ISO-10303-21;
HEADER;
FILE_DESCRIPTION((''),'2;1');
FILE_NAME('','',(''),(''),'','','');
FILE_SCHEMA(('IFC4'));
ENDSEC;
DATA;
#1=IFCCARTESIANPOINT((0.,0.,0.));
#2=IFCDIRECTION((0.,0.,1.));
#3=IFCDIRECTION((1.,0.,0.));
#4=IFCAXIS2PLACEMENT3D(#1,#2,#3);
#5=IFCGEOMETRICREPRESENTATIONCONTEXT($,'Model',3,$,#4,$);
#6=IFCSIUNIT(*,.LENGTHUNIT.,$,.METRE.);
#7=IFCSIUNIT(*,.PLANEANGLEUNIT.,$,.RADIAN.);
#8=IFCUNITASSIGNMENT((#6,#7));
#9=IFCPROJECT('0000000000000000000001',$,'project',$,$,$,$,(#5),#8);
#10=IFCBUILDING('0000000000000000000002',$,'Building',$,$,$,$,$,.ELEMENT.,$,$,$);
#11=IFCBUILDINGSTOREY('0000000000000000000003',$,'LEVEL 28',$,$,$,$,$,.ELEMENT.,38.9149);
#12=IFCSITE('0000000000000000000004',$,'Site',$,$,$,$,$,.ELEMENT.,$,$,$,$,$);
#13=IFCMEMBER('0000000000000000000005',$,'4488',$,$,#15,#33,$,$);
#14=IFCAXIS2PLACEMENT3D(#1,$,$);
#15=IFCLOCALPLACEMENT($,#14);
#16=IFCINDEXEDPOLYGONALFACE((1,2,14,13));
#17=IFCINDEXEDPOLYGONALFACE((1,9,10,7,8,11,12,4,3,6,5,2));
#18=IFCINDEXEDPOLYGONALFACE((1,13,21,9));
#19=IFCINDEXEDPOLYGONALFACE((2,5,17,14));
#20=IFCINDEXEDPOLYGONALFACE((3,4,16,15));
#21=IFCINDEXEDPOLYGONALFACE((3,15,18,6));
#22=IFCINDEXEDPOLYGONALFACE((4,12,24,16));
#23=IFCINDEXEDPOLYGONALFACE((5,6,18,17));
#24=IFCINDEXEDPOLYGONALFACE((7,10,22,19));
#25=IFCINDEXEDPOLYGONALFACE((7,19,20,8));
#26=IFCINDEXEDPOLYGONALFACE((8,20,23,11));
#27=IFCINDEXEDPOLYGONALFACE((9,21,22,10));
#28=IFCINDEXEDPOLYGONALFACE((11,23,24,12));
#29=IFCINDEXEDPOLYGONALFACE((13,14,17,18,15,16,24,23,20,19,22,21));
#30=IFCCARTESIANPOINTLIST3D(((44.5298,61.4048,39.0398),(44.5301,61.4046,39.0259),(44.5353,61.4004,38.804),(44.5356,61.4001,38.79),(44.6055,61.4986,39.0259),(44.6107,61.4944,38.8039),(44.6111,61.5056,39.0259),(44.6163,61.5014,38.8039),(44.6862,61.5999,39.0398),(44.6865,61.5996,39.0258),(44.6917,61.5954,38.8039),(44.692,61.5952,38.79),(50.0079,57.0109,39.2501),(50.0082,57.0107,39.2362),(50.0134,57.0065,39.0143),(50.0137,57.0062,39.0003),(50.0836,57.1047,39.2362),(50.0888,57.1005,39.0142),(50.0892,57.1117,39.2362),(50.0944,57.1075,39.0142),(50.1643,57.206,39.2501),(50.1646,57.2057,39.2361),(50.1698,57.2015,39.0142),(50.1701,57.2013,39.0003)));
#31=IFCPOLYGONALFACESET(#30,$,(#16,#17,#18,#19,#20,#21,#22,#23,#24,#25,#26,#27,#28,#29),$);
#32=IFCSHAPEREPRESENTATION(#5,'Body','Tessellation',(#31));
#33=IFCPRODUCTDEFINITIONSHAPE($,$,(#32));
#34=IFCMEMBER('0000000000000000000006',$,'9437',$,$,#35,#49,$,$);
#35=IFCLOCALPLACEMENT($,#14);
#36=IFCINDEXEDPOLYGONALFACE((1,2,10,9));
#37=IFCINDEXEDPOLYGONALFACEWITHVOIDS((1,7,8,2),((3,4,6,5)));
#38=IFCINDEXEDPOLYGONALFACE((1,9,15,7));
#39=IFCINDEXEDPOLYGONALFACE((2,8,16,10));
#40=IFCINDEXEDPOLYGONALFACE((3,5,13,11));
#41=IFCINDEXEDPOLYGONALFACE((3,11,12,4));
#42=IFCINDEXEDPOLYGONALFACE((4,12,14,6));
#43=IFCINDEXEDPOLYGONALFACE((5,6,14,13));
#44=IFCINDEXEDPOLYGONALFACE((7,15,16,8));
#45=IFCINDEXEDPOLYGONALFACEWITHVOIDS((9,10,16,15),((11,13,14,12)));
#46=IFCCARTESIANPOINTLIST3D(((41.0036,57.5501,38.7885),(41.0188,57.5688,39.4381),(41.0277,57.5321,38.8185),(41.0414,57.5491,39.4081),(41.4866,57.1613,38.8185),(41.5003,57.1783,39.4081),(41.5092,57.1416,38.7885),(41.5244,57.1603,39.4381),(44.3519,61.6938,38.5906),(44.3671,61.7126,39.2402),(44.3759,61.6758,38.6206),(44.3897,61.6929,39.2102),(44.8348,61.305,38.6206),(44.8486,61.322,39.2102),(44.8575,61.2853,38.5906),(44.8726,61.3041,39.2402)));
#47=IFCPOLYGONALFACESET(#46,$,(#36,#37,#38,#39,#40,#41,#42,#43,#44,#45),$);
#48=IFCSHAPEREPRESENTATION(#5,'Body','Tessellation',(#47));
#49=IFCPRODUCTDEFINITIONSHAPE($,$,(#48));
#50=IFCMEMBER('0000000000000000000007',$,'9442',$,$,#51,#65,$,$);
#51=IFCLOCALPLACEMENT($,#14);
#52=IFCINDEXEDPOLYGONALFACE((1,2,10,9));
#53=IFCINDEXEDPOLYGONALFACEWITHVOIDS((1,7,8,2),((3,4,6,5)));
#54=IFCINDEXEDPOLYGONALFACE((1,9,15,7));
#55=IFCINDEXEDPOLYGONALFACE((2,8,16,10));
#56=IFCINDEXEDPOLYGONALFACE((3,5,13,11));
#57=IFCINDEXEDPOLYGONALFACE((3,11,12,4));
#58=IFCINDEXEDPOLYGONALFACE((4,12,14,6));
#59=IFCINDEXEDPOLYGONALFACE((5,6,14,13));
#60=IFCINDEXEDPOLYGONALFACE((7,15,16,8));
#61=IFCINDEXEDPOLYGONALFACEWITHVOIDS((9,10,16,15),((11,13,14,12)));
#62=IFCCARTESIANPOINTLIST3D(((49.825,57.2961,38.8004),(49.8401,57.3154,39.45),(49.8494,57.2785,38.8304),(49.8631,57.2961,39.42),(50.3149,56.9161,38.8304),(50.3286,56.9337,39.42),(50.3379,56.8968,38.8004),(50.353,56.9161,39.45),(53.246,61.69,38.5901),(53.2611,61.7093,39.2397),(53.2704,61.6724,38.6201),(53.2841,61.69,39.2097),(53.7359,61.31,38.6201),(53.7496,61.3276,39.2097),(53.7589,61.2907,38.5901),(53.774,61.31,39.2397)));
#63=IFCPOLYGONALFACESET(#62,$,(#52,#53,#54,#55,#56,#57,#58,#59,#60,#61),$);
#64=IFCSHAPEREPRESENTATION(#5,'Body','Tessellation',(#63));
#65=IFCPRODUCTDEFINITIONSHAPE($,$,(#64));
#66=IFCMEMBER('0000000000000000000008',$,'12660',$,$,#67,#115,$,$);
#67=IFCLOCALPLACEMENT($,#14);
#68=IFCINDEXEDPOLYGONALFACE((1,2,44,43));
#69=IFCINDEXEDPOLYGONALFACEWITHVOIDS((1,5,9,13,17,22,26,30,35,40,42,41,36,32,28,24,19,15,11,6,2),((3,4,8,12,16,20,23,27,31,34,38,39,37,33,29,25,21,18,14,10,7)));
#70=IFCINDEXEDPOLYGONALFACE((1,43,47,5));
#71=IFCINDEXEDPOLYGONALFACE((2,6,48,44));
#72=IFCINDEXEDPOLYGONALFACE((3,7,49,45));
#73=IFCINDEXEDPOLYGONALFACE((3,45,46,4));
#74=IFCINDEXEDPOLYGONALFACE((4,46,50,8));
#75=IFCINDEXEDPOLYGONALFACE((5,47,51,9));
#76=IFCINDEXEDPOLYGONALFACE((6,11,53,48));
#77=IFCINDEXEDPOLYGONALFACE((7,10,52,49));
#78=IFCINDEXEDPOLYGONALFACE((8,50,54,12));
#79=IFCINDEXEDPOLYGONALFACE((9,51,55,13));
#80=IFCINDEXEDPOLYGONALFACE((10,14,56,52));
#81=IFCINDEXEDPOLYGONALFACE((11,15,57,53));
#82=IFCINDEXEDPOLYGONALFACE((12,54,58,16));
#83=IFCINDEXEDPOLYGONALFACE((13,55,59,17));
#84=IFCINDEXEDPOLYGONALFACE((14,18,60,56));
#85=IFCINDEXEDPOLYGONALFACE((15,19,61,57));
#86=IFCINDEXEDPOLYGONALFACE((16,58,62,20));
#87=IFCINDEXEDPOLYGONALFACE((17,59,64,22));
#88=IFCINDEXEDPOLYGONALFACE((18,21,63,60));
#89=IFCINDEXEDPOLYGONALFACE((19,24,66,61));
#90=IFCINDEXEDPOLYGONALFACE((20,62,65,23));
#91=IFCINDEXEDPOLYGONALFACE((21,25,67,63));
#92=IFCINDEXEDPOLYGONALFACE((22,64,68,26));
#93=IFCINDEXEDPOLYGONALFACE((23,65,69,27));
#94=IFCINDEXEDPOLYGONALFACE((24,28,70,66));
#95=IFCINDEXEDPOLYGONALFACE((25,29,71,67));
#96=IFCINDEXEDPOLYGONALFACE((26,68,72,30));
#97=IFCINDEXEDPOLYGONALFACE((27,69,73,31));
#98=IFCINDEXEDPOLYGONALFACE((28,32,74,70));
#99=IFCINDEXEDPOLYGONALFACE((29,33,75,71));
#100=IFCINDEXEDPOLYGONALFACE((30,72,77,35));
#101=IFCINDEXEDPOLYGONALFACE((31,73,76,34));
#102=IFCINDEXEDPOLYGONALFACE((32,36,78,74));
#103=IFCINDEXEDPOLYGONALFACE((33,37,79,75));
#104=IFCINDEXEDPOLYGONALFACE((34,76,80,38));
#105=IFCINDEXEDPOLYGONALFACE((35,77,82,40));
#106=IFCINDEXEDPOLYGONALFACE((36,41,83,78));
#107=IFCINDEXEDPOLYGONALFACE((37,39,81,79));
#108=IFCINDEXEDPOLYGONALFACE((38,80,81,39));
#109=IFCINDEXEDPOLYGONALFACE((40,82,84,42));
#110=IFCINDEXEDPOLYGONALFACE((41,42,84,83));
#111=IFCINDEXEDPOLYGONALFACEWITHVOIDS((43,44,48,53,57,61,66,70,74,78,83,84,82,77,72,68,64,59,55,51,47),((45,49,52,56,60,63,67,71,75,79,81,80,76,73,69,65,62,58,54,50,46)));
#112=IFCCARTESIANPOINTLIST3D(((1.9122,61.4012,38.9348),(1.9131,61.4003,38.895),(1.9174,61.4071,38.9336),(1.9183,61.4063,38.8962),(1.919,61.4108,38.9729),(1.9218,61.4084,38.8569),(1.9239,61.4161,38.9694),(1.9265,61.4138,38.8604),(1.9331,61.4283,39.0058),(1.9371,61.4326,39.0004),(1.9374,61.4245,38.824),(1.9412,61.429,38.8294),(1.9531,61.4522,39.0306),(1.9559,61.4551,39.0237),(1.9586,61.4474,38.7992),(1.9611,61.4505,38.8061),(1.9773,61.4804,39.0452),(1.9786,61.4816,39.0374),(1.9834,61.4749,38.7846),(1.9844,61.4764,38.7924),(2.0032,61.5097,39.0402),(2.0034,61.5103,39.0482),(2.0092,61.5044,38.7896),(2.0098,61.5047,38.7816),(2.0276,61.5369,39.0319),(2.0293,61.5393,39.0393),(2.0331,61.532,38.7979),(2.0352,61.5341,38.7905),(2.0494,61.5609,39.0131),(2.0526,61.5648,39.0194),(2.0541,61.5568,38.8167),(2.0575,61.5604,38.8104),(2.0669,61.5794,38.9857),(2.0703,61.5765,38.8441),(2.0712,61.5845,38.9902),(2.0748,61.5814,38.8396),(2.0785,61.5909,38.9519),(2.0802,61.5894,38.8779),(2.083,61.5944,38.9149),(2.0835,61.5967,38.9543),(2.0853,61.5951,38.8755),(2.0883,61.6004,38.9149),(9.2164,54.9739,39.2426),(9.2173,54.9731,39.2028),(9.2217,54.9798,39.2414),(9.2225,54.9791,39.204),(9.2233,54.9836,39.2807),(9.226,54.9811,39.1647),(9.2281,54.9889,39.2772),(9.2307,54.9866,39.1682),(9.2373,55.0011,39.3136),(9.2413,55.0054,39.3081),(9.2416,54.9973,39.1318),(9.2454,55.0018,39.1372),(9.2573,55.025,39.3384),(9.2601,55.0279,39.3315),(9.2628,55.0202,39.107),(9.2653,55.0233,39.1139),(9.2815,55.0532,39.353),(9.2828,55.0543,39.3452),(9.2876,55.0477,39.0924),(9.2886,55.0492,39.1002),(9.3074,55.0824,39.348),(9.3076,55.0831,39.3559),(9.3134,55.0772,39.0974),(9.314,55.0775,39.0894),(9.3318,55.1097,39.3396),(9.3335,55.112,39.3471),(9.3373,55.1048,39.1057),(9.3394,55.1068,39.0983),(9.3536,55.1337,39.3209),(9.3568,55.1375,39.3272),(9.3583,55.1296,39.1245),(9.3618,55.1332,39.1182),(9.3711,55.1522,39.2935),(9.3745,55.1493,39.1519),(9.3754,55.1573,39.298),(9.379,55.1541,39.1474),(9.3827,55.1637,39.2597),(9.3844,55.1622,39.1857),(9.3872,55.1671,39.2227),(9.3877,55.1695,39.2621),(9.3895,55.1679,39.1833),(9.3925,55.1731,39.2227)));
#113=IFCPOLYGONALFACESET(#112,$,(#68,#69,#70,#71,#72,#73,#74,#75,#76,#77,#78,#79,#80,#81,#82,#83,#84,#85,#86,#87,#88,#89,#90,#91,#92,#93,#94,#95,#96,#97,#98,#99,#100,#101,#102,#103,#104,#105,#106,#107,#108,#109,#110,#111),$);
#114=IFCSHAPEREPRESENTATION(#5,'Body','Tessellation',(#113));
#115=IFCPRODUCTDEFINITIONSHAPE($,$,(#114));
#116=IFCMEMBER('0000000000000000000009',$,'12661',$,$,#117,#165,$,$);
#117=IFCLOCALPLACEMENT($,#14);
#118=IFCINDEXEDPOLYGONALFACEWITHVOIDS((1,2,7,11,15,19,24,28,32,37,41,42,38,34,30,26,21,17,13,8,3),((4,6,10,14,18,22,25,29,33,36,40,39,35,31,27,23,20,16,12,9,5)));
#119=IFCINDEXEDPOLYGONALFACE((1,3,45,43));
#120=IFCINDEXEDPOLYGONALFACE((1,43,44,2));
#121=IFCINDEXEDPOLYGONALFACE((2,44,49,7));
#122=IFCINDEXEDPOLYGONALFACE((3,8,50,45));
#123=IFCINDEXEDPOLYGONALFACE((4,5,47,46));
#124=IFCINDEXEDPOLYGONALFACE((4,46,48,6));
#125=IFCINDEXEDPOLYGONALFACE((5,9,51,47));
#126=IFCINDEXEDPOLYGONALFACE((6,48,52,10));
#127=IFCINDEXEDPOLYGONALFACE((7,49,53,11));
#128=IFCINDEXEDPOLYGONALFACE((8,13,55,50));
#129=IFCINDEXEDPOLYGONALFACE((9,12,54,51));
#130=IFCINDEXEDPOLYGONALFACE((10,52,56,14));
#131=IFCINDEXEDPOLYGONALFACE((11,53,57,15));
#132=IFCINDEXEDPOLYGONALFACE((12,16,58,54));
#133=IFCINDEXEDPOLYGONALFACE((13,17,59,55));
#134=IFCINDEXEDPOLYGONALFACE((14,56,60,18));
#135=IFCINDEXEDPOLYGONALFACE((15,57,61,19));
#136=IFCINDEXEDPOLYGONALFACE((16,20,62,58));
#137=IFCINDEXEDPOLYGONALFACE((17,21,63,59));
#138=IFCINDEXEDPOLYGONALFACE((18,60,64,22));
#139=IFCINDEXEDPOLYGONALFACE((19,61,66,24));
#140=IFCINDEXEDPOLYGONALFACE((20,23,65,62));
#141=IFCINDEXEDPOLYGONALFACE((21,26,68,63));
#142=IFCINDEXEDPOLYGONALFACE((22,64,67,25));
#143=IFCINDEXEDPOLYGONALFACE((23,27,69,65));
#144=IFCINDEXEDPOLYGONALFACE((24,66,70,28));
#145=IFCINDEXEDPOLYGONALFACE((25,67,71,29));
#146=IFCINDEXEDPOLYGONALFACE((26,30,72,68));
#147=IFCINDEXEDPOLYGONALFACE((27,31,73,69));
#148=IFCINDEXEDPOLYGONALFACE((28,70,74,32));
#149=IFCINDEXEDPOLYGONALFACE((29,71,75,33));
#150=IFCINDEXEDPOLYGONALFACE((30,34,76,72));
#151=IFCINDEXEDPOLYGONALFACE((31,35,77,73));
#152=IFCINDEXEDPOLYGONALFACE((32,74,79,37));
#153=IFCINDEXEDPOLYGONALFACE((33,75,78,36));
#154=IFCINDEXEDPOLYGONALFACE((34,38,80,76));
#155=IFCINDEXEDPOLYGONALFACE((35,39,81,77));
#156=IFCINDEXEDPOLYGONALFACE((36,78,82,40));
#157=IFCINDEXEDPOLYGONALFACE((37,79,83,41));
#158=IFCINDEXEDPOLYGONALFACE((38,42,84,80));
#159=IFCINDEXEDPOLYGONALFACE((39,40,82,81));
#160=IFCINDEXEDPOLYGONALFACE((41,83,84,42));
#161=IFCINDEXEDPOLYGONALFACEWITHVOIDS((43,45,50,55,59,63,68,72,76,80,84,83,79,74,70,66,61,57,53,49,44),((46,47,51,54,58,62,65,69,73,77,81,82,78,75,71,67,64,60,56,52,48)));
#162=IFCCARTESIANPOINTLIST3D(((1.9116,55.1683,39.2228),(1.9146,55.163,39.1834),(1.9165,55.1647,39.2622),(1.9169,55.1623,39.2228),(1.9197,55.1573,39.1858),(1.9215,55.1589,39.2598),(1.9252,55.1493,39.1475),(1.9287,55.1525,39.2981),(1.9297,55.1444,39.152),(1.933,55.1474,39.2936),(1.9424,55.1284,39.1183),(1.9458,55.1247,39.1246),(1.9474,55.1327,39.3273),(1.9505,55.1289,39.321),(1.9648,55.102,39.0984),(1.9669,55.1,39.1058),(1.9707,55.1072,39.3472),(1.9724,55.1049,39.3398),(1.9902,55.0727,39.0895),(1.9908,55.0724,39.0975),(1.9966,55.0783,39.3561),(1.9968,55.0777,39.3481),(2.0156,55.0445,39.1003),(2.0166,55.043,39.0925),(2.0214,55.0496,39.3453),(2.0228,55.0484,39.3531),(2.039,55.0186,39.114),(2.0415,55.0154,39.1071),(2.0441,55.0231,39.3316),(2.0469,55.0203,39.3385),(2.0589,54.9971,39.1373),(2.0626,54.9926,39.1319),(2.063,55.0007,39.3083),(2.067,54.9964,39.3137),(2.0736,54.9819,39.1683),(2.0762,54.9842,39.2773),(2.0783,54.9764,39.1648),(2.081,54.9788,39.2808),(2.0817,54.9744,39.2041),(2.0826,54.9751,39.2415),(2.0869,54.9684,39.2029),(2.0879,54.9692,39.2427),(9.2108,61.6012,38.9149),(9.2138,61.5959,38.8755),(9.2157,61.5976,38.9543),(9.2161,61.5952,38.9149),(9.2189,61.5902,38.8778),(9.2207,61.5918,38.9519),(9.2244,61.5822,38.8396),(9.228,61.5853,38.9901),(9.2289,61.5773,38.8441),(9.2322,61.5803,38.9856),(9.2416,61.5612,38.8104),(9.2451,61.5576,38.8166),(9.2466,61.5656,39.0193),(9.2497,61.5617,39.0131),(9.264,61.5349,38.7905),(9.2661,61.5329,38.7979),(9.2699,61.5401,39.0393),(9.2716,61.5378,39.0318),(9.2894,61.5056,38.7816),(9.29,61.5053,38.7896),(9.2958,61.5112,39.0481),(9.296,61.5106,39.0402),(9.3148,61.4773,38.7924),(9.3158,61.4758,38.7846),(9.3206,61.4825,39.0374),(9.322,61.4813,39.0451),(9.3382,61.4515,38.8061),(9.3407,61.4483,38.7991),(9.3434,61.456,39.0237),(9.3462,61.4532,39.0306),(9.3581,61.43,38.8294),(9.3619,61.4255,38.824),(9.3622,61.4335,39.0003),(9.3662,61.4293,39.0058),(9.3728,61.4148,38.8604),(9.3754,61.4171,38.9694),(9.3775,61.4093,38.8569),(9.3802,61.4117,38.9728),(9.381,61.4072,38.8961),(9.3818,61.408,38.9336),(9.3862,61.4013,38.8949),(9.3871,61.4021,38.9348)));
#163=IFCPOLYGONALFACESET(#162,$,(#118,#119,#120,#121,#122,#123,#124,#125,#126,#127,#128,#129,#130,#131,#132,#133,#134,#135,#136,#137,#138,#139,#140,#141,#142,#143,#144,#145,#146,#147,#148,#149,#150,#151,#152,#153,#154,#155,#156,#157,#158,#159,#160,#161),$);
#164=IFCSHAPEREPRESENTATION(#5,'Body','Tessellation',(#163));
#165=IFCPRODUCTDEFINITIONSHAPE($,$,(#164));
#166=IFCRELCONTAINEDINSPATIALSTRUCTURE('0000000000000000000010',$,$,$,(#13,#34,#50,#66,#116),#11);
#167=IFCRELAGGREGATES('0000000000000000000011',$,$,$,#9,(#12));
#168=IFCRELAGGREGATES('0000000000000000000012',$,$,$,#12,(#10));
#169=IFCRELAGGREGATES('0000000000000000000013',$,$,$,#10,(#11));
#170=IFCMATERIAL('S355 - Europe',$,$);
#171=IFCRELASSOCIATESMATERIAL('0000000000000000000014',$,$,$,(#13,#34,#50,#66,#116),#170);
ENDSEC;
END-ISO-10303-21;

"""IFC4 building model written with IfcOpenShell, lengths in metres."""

from ifc_helpers import new_model, si_unit, frame, origin_with_axes, origin_2d_with_axis, place, context, project, spatial, hollow_rectangle, hollow_circle, i_section, extrude, material, material_profile, profile_set, profile_usage, element, save


model = new_model("IFC4")

# Units and contexts
model_context = context("Model", 3, world=origin_with_axes())
ifc_project = project(units=[si_unit("LENGTHUNIT", "METRE"), si_unit("PLANEANGLEUNIT", "RADIAN")], contexts=[model_context])

# Site, building, storey
site = spatial("IfcSite", under=ifc_project, Name="Site", CompositionType="ELEMENT")
building = spatial("IfcBuilding", under=site, Name="Building", CompositionType="ELEMENT")
storey = spatial("IfcBuildingStorey", under=building, Name="LEVEL 28", CompositionType="ELEMENT", Elevation=38.9149)

# Shared definitions
ifc_material = material(Name="S355 - Europe")

# Members
ifc_material_profile_1 = material_profile(ifc_material, i_section(OverallWidth=0.25, OverallDepth=0.25, WebThickness=0.009, FlangeThickness=0.014, at=origin_2d_with_axis()))
ifc_profile_set_1 = profile_set([ifc_material_profile_1])
ifc_profile_usage_1 = profile_usage(ifc_profile_set_1, cardinal=10)
member_1_placement = place(None, frame((50.089, 57.1061, 39.1252), z_axis=(-0.779725, 0.625406, -0.029933), x_axis=(-0.626214, -0.779651, 0.0)))
element("IfcMember", 1, at=member_1_placement, inside=storey, material=ifc_profile_usage_1, Name="4488", context=model_context, shape_type="SweptSolid", body=[
    extrude(i_section(OverallWidth=0.25, OverallDepth=0.25, WebThickness=0.009, FlangeThickness=0.014, at=origin_2d_with_axis()), origin_with_axes(), (0.0, 0.0, 1.0), 7.0257),
])
ifc_material_profile_2 = material_profile(ifc_material, hollow_rectangle(XDim=0.65, YDim=0.65, WallThickness=0.03, at=origin_2d_with_axis()))
ifc_profile_set_2 = profile_set([ifc_material_profile_2])
ifc_profile_usage_2 = profile_usage(ifc_profile_set_2, cardinal=10)
member_2_placement = place(None, frame((41.264, 57.3552, 39.1133), z_axis=(0.628063, 0.777276, -0.037125), x_axis=(-0.777826, 0.62848, 0.0)))
element("IfcMember", 2, at=member_2_placement, inside=storey, material=ifc_profile_usage_2, Name="9437", context=model_context, shape_type="SweptSolid", body=[
    extrude(hollow_rectangle(XDim=0.65, YDim=0.65, WallThickness=0.03, at=origin_2d_with_axis()), origin_with_axes(), (0.0, 0.0, 1.0), 5.3311),
])
ifc_material_profile_3 = material_profile(ifc_material, hollow_rectangle(XDim=0.65, YDim=0.65, WallThickness=0.03, at=origin_2d_with_axis()))
ifc_profile_set_3 = profile_set([ifc_material_profile_3])
ifc_profile_usage_3 = profile_usage(ifc_profile_set_3, cardinal=10)
member_3_placement = place(None, frame((53.51, 61.5, 38.9149), z_axis=(-0.613897, -0.788484, 0.037738), x_axis=(0.789796, -0.61337, 0.0)))
element("IfcMember", 3, at=member_3_placement, inside=storey, material=ifc_profile_usage_3, Name="9442", context=model_context, shape_type="SweptSolid", body=[
    extrude(hollow_rectangle(XDim=0.65, YDim=0.65, WallThickness=0.03, at=origin_2d_with_axis()), origin_with_axes(), (0.0, 0.0, 1.0), 5.5726),
])
ifc_material_profile_4 = material_profile(ifc_material, hollow_circle(Radius=0.1337, WallThickness=0.008, at=origin_2d_with_axis()))
ifc_profile_set_4 = profile_set([ifc_material_profile_4])
ifc_profile_usage_4 = profile_usage(ifc_profile_set_4, cardinal=10)
member_4_placement = place(None, frame((2.0, 61.5, 38.9149), z_axis=(0.750362, -0.66027, 0.031619), x_axis=(0.6606, 0.750738, 0.0)))
element("IfcMember", 4, at=member_4_placement, inside=storey, material=ifc_profile_usage_4, Name="12660", context=model_context, shape_type="SweptSolid", body=[
    extrude(hollow_circle(Radius=0.1337, WallThickness=0.008, at=origin_2d_with_axis()), origin_with_axes(), (0.0, 0.0, 1.0), 9.7342),
])
ifc_material_profile_5 = material_profile(ifc_material, hollow_circle(Radius=0.1337, WallThickness=0.008, at=origin_2d_with_axis()))
ifc_profile_set_5 = profile_set([ifc_material_profile_5])
ifc_profile_usage_5 = profile_usage(ifc_profile_set_5, cardinal=10)
member_5_placement = place(None, frame((2.0, 55.068, 39.2228), z_axis=(0.749849, 0.660852, -0.031634), x_axis=(-0.661183, 0.750225, 0.0)))
element("IfcMember", 5, at=member_5_placement, inside=storey, material=ifc_profile_usage_5, Name="12661", context=model_context, shape_type="SweptSolid", body=[
    extrude(hollow_circle(Radius=0.1337, WallThickness=0.008, at=origin_2d_with_axis()), origin_with_axes(), (0.0, 0.0, 1.0), 9.7342),
])

save(model, "model.ifc")
